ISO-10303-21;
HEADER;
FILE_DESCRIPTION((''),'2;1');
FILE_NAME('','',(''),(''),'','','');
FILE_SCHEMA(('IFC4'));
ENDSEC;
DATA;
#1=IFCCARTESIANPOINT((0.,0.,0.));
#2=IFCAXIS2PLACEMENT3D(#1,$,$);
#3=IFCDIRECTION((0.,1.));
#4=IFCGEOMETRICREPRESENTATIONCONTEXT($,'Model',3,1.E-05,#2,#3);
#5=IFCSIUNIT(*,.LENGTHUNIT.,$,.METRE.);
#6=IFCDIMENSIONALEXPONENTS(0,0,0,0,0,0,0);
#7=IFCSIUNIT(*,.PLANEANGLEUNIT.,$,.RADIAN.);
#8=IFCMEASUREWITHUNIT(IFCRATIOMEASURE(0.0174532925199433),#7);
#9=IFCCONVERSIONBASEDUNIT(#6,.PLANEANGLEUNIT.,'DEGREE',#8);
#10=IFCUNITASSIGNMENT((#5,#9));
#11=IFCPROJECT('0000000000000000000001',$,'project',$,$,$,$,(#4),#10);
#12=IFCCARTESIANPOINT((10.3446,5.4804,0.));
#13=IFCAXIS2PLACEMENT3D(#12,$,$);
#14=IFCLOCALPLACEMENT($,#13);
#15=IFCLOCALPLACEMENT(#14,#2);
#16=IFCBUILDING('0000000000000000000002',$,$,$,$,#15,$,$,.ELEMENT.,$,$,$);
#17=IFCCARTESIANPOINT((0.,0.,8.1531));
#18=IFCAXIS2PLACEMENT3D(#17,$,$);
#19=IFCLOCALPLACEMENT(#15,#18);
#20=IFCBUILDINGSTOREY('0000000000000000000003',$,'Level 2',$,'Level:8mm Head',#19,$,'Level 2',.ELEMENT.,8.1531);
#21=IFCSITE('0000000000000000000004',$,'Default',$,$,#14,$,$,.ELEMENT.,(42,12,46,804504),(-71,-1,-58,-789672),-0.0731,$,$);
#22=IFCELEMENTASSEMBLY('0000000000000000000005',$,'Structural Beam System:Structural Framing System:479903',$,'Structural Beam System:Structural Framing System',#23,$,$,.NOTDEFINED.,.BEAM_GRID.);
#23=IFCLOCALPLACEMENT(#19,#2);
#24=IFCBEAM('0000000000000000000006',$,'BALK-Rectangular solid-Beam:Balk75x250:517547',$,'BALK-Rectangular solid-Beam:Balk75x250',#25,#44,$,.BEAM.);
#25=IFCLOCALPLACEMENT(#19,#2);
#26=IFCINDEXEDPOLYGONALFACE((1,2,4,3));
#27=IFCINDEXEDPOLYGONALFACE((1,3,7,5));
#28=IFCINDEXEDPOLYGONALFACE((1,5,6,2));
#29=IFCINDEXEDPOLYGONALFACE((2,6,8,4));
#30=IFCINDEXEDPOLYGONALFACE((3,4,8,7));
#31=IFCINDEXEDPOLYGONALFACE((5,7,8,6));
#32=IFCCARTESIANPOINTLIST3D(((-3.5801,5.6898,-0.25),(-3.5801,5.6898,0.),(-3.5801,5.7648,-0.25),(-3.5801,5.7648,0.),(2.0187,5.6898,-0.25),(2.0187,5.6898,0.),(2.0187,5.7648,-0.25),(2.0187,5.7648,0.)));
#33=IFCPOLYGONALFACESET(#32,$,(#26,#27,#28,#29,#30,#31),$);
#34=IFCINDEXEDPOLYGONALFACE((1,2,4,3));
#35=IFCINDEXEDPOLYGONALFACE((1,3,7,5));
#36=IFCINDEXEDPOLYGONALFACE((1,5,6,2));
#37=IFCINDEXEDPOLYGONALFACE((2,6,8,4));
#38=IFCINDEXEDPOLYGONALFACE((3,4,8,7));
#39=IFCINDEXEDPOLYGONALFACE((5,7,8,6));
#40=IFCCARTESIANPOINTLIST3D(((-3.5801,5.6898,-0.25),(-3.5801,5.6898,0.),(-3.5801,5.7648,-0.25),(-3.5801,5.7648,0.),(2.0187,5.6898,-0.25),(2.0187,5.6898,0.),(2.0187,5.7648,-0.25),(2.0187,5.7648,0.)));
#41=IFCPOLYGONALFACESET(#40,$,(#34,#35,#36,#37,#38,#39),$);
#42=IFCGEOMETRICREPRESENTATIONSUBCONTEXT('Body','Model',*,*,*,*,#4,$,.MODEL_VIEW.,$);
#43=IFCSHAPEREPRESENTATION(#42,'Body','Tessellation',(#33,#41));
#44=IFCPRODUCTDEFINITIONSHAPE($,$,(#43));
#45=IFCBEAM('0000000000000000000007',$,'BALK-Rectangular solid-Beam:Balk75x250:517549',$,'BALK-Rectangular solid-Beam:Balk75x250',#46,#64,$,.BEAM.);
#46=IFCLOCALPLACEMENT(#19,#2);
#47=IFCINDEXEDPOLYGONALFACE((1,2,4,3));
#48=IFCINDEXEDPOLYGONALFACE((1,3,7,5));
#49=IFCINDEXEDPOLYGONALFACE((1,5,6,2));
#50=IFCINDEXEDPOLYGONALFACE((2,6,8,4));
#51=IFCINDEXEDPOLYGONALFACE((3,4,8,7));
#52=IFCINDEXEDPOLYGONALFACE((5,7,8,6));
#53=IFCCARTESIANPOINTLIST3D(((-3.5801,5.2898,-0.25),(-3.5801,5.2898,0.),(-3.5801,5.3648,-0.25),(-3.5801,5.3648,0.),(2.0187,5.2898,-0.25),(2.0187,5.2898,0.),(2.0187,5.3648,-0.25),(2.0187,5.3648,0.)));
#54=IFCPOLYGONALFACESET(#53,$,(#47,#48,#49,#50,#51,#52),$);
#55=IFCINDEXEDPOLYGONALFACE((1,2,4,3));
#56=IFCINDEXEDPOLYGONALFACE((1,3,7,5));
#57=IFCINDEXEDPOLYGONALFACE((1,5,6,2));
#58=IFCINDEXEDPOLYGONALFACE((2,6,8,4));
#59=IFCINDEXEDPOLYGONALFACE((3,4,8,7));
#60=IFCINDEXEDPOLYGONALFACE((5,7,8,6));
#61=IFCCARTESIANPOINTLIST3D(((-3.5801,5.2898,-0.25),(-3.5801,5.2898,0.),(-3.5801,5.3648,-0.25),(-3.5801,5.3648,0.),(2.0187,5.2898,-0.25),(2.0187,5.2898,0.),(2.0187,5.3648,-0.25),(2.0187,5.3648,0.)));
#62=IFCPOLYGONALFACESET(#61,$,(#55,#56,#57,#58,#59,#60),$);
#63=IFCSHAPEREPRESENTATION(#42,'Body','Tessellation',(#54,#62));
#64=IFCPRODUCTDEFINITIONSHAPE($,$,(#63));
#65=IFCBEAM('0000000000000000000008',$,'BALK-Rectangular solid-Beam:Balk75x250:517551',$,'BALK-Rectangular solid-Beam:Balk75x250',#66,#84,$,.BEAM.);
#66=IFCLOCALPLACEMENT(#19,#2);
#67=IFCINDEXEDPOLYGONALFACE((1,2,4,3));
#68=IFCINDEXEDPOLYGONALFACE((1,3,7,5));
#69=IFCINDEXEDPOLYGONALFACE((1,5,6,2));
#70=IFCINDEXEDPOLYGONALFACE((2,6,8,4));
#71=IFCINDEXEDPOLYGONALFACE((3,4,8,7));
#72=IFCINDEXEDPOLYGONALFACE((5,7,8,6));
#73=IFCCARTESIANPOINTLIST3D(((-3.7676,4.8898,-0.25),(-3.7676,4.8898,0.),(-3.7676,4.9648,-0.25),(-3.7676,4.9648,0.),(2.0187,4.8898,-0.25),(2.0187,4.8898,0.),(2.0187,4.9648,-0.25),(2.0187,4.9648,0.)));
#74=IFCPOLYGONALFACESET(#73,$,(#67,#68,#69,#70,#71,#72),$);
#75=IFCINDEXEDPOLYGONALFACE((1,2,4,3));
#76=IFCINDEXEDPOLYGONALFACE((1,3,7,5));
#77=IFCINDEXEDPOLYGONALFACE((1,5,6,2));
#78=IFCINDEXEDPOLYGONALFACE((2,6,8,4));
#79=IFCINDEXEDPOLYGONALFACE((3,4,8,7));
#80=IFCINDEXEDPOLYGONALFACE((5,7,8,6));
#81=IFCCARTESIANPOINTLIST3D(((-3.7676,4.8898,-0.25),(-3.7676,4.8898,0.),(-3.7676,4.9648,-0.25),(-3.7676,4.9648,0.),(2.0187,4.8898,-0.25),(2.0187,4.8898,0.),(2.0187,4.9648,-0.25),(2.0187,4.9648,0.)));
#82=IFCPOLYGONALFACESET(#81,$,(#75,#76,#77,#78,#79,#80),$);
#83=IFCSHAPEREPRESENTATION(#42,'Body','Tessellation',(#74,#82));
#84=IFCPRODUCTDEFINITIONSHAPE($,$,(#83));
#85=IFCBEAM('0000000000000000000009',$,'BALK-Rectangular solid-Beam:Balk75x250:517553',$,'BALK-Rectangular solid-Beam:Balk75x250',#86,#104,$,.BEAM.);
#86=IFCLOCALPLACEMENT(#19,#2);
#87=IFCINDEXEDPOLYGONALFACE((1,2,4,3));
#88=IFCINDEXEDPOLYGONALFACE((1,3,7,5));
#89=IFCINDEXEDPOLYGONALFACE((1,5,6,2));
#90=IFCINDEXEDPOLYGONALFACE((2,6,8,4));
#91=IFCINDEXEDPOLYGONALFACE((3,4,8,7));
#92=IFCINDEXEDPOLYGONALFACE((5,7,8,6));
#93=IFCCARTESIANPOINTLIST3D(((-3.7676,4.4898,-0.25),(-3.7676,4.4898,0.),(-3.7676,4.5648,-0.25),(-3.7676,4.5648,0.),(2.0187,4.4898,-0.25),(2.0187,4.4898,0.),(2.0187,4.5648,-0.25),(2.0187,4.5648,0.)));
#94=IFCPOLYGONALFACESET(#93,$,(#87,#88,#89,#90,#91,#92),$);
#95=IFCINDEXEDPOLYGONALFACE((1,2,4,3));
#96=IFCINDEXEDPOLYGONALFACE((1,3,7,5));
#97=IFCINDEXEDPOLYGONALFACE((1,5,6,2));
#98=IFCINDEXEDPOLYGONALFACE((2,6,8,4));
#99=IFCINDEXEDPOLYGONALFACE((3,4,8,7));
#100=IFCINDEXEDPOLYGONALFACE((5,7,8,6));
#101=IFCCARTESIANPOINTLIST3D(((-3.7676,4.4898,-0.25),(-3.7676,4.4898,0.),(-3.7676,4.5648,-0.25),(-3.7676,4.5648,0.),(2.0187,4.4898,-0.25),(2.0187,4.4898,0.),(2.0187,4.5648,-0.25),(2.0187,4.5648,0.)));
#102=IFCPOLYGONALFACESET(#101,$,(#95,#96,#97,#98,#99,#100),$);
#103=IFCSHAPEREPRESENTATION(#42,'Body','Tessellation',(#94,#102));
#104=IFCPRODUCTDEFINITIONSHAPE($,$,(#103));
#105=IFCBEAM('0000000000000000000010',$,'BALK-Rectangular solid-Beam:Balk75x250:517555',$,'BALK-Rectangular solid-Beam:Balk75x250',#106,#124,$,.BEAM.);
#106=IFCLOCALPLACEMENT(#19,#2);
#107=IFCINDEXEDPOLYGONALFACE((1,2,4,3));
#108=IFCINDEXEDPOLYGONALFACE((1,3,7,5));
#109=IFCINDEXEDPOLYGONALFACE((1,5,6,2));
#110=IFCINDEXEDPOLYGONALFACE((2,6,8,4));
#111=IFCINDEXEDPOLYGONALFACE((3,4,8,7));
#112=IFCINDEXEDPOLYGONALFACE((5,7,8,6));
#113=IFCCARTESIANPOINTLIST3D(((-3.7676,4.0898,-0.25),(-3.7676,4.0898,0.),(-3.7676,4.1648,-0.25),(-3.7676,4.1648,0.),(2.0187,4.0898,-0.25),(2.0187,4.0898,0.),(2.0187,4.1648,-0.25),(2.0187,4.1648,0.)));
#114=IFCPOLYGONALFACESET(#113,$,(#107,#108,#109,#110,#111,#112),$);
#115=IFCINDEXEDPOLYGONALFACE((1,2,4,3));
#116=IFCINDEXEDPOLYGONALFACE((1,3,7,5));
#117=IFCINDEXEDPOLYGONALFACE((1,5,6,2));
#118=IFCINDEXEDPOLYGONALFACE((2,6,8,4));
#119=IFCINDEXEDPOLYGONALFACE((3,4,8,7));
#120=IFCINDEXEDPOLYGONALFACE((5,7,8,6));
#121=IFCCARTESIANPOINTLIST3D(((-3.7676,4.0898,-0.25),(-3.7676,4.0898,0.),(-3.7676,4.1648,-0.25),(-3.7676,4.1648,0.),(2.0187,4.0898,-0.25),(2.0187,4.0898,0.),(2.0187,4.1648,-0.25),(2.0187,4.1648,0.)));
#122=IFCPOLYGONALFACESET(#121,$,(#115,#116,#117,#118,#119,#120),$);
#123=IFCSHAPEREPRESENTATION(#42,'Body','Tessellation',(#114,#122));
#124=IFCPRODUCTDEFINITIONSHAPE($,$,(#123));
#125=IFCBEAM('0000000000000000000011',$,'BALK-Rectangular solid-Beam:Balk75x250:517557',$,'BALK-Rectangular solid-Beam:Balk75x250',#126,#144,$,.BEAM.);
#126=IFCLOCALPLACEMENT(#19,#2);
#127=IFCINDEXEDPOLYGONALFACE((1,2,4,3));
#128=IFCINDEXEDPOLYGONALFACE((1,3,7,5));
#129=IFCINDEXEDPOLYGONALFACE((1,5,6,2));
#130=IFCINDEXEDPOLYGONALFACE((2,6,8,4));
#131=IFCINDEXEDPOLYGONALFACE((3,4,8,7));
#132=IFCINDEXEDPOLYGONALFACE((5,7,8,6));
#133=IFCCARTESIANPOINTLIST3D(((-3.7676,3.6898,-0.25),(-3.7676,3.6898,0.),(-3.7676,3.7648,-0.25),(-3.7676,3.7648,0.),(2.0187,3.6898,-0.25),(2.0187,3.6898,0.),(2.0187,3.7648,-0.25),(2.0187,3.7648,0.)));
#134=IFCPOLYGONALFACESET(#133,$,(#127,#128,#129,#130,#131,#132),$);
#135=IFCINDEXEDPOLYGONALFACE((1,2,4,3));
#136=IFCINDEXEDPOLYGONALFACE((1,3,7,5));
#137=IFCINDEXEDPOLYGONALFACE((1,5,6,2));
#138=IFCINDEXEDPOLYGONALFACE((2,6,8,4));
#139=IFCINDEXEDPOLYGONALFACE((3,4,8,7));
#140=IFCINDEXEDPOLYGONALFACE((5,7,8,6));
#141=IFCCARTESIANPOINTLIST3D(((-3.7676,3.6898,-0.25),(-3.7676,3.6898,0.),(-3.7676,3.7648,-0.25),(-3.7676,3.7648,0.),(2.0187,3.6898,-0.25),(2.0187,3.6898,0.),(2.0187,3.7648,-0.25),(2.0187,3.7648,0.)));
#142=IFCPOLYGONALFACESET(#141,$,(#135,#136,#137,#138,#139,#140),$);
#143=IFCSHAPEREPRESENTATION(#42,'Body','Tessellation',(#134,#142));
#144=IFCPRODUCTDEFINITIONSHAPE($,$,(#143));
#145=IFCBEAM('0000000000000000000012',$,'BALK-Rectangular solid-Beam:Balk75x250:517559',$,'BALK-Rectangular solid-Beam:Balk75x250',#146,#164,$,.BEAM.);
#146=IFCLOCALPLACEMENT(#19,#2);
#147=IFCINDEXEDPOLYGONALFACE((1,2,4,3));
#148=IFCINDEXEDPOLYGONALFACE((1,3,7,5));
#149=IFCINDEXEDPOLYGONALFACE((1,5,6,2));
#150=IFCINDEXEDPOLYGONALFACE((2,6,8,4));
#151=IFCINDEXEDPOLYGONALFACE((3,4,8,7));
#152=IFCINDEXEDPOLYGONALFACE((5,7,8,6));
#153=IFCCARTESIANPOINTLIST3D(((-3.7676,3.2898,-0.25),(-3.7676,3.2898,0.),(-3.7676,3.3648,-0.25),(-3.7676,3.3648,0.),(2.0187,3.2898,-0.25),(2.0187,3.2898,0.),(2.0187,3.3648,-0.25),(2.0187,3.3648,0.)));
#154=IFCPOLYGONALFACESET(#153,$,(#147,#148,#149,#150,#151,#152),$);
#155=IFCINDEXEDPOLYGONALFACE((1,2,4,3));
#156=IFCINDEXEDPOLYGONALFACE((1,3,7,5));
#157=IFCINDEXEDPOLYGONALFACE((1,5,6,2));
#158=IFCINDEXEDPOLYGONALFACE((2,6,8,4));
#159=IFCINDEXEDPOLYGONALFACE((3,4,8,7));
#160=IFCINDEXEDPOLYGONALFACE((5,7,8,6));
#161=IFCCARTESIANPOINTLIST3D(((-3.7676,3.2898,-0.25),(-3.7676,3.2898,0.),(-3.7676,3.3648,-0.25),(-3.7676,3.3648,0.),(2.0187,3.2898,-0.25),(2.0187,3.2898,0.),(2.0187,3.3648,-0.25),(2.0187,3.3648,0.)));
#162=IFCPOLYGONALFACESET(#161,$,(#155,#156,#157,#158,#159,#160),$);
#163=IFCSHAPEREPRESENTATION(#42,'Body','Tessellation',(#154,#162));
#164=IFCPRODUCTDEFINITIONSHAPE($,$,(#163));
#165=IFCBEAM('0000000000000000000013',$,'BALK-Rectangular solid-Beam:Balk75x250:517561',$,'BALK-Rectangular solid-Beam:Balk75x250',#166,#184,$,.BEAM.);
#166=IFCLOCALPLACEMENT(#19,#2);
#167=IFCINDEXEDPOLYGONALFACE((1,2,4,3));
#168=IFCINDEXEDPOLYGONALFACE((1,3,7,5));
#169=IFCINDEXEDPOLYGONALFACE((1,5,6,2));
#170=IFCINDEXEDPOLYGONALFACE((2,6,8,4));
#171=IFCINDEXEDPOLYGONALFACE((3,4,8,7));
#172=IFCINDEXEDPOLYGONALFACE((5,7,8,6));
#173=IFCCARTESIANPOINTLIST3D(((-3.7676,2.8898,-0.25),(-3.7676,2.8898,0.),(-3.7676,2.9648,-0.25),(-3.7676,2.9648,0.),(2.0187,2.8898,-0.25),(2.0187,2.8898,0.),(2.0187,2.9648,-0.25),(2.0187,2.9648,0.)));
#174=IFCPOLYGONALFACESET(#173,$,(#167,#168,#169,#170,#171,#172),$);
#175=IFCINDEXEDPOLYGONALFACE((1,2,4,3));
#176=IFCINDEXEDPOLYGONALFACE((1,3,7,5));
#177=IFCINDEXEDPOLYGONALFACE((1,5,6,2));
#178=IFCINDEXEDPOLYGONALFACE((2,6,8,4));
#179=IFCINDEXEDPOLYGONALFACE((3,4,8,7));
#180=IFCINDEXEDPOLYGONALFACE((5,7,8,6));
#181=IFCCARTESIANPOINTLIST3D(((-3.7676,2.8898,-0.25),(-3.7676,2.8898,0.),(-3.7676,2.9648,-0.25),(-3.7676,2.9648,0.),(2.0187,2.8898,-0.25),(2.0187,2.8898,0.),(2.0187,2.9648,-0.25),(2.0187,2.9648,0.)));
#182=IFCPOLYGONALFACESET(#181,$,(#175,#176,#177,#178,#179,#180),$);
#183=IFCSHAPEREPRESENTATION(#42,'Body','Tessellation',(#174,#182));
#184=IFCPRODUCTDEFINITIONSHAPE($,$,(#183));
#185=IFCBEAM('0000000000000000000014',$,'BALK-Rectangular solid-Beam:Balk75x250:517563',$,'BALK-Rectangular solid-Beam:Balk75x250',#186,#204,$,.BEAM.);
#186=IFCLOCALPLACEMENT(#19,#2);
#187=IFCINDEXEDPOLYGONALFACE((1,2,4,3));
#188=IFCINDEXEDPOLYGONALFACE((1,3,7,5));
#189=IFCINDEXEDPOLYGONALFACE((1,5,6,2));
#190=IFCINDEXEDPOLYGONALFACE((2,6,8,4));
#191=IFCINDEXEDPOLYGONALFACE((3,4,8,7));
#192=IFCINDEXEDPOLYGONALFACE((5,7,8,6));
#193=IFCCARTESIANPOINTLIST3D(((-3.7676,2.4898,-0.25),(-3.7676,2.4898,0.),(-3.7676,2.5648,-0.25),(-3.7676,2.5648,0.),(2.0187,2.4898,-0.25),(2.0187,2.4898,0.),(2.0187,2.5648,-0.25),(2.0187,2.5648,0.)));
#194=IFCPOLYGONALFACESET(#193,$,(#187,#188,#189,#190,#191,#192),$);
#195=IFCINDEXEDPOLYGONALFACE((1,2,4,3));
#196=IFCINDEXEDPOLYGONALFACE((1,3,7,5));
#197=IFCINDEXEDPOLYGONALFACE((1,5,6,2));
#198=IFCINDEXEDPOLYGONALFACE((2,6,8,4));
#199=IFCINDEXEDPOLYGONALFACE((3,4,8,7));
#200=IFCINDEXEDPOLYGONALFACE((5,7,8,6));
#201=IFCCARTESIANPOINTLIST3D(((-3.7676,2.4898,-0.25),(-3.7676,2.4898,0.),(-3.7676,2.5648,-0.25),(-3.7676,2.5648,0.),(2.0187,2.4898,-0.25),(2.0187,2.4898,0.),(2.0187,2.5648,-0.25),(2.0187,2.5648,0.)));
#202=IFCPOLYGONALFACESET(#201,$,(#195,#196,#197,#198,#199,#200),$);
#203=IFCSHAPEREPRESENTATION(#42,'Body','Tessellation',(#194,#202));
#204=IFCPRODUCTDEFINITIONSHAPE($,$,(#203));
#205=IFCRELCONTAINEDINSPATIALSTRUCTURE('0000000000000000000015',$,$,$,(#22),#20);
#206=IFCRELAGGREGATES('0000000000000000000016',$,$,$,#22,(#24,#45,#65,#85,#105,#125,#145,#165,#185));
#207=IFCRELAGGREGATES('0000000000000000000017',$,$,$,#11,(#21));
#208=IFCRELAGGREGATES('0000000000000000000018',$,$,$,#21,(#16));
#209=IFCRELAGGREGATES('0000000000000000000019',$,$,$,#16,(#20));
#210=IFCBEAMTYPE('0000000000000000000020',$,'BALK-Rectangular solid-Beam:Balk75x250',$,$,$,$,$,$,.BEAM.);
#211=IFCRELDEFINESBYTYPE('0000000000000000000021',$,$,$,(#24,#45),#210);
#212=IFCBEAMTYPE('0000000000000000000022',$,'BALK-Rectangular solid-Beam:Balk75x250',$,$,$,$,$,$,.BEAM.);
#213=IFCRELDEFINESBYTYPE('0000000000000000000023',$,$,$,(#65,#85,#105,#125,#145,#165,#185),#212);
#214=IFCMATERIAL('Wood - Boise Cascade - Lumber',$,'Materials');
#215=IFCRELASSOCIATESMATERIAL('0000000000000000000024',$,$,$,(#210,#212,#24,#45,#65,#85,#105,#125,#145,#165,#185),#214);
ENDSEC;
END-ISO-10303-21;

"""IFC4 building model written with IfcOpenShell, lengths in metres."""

from ifc_helpers import new_model, entity, si_unit, converted_unit, direction, frame, frame_2d, origin, origin_2d_with_axis, place, context, subcontext, project, spatial, rectangle, extrude, source, transform, mapped, material, material_profile, profile_set, profile_usage, type_object, type_shapes, element, aggregate, save


model = new_model("IFC4")

# Units and contexts
model_context = context("Model", 3, precision=1e-05, world=origin(), true_north=direction((0.0, 1.0)))
body_context = subcontext(model_context, "Body", "Model", "MODEL_VIEW")
ifc_project = project(units=[si_unit("LENGTHUNIT", "METRE"), converted_unit("PLANEANGLEUNIT", "DEGREE", entity("IfcRatioMeasure", 0.0174532925199433), si_unit("PLANEANGLEUNIT", "RADIAN"), dimensions=[0, 0, 0, 0, 0, 0, 0])], contexts=[model_context])

# Site, building, storey
site_placement = place(None, frame((10.3446, 5.4804, 0.0)))
site = spatial("IfcSite", under=ifc_project, at=site_placement, Name="Default", CompositionType="ELEMENT", RefLatitude=(42, 12, 46, 804504), RefLongitude=(-71, -1, -58, -789672), RefElevation=-0.0731)
building_placement = place(site_placement, origin())
building = spatial("IfcBuilding", under=site, at=building_placement, CompositionType="ELEMENT")
storey_placement = place(building_placement, frame((0.0, 0.0, 8.1531)))
storey = spatial("IfcBuildingStorey", under=building, at=storey_placement, Name="Level 2", ObjectType="Level:8mm Head", LongName="Level 2", CompositionType="ELEMENT", Elevation=8.1531)

# Element assembly, beams
ifc_material_1 = material(Name="Wood - Boise Cascade - Lumber", Category="Materials")
ifc_material_profile = material_profile(ifc_material_1, rectangle(XDim=0.25, YDim=0.075, at=frame_2d((0.0, 0.0), x_axis=(1.0, 0.0))), Name="Balk75x250")
ifc_profile_set = profile_set([ifc_material_profile], Name="Balk75x250")
assembly_1_placement = place(storey_placement, origin())
assembly_1 = element("IfcElementAssembly", 1, at=assembly_1_placement, inside=storey, Name="Structural Beam System:Structural Framing System:479903", ObjectType="Structural Beam System:Structural Framing System", AssemblyPlace="NOTDEFINED", PredefinedType="BEAM_GRID")
ifc_profile_usage_1 = profile_usage(ifc_profile_set, cardinal=8)
beam_type_1 = type_object("IfcBeamType", Name="BALK-Rectangular solid-Beam:Balk75x250", PredefinedType="BEAM", material=ifc_profile_set)
shared_shape_1 = source(origin(), body_context, "Body", "SweptSolid", [
    extrude(rectangle(XDim=0.25, YDim=0.075, at=origin_2d_with_axis()), frame((-2.7994, 0.0, 0.0), z_axis=(1.0, 0.0, 0.0), x_axis=(0.0, 0.0, -1.0)), (0.0, 0.0, 1.0), 5.5988),
    extrude(rectangle(XDim=0.25, YDim=0.075, at=origin_2d_with_axis()), frame((-2.7994, 0.0, 0.0), z_axis=(1.0, 0.0, 0.0), x_axis=(0.0, 0.0, -1.0)), (0.0, 0.0, 1.0), 5.5988),
])
type_shapes(beam_type_1, [shared_shape_1])
beam_1_placement = place(assembly_1_placement, frame((-0.7807, 5.7273, -0.125)))
beam_1 = element("IfcBeam", 2, at=beam_1_placement, type_object=beam_type_1, material=ifc_profile_usage_1, Name="BALK-Rectangular solid-Beam:Balk75x250:517547", ObjectType="BALK-Rectangular solid-Beam:Balk75x250", PredefinedType="BEAM", context=body_context, shape_type="MappedRepresentation", body=[
    mapped(shared_shape_1, transform((0.0, 0.0, 0.0), scale=1.0)),
])
ifc_profile_usage_2 = profile_usage(ifc_profile_set, cardinal=8)
beam_2_placement = place(assembly_1_placement, frame((-0.7807, 5.3273, -0.125)))
beam_2 = element("IfcBeam", 3, at=beam_2_placement, type_object=beam_type_1, material=ifc_profile_usage_2, Name="BALK-Rectangular solid-Beam:Balk75x250:517549", ObjectType="BALK-Rectangular solid-Beam:Balk75x250", PredefinedType="BEAM", context=body_context, shape_type="MappedRepresentation", body=[
    mapped(shared_shape_1, transform((0.0, 0.0, 0.0), scale=1.0)),
])
ifc_profile_usage_3 = profile_usage(ifc_profile_set, cardinal=8)
beam_type_2 = type_object("IfcBeamType", Name="BALK-Rectangular solid-Beam:Balk75x250", PredefinedType="BEAM", material=ifc_profile_set)
shared_shape_2 = source(origin(), body_context, "Body", "SweptSolid", [
    extrude(rectangle(XDim=0.25, YDim=0.075, at=origin_2d_with_axis()), frame((-2.9869, 0.0, 0.0), z_axis=(1.0, 0.0, 0.0), x_axis=(0.0, 0.0, -1.0)), (0.0, 0.0, 1.0), 5.7863),
    extrude(rectangle(XDim=0.25, YDim=0.075, at=origin_2d_with_axis()), frame((-2.9869, 0.0, 0.0), z_axis=(1.0, 0.0, 0.0), x_axis=(0.0, 0.0, -1.0)), (0.0, 0.0, 1.0), 5.7863),
])
type_shapes(beam_type_2, [shared_shape_2])
beam_3_placement = place(assembly_1_placement, frame((-0.7807, 4.9273, -0.125)))
beam_3 = element("IfcBeam", 4, at=beam_3_placement, type_object=beam_type_2, material=ifc_profile_usage_3, Name="BALK-Rectangular solid-Beam:Balk75x250:517551", ObjectType="BALK-Rectangular solid-Beam:Balk75x250", PredefinedType="BEAM", context=body_context, shape_type="MappedRepresentation", body=[
    mapped(shared_shape_2, transform((0.0, 0.0, 0.0), scale=1.0)),
])
ifc_profile_usage_4 = profile_usage(ifc_profile_set, cardinal=8)
beam_4_placement = place(assembly_1_placement, frame((-0.7807, 4.5273, -0.125)))
beam_4 = element("IfcBeam", 5, at=beam_4_placement, type_object=beam_type_2, material=ifc_profile_usage_4, Name="BALK-Rectangular solid-Beam:Balk75x250:517553", ObjectType="BALK-Rectangular solid-Beam:Balk75x250", PredefinedType="BEAM", context=body_context, shape_type="MappedRepresentation", body=[
    mapped(shared_shape_2, transform((0.0, 0.0, 0.0), scale=1.0)),
])
ifc_profile_usage_5 = profile_usage(ifc_profile_set, cardinal=8)
beam_5_placement = place(assembly_1_placement, frame((-0.7807, 4.1273, -0.125)))
beam_5 = element("IfcBeam", 6, at=beam_5_placement, type_object=beam_type_2, material=ifc_profile_usage_5, Name="BALK-Rectangular solid-Beam:Balk75x250:517555", ObjectType="BALK-Rectangular solid-Beam:Balk75x250", PredefinedType="BEAM", context=body_context, shape_type="MappedRepresentation", body=[
    mapped(shared_shape_2, transform((0.0, 0.0, 0.0), scale=1.0)),
])
ifc_profile_usage_6 = profile_usage(ifc_profile_set, cardinal=8)
beam_6_placement = place(assembly_1_placement, frame((-0.7807, 3.7273, -0.125)))
beam_6 = element("IfcBeam", 7, at=beam_6_placement, type_object=beam_type_2, material=ifc_profile_usage_6, Name="BALK-Rectangular solid-Beam:Balk75x250:517557", ObjectType="BALK-Rectangular solid-Beam:Balk75x250", PredefinedType="BEAM", context=body_context, shape_type="MappedRepresentation", body=[
    mapped(shared_shape_2, transform((0.0, 0.0, 0.0), scale=1.0)),
])
ifc_profile_usage_7 = profile_usage(ifc_profile_set, cardinal=8)
beam_7_placement = place(assembly_1_placement, frame((-0.7807, 3.3273, -0.125)))
beam_7 = element("IfcBeam", 8, at=beam_7_placement, type_object=beam_type_2, material=ifc_profile_usage_7, Name="BALK-Rectangular solid-Beam:Balk75x250:517559", ObjectType="BALK-Rectangular solid-Beam:Balk75x250", PredefinedType="BEAM", context=body_context, shape_type="MappedRepresentation", body=[
    mapped(shared_shape_2, transform((0.0, 0.0, 0.0), scale=1.0)),
])
ifc_profile_usage_8 = profile_usage(ifc_profile_set, cardinal=8)
beam_8_placement = place(assembly_1_placement, frame((-0.7807, 2.9273, -0.125)))
beam_8 = element("IfcBeam", 9, at=beam_8_placement, type_object=beam_type_2, material=ifc_profile_usage_8, Name="BALK-Rectangular solid-Beam:Balk75x250:517561", ObjectType="BALK-Rectangular solid-Beam:Balk75x250", PredefinedType="BEAM", context=body_context, shape_type="MappedRepresentation", body=[
    mapped(shared_shape_2, transform((0.0, 0.0, 0.0), scale=1.0)),
])
ifc_profile_usage_9 = profile_usage(ifc_profile_set, cardinal=8)
beam_9_placement = place(assembly_1_placement, frame((-0.7807, 2.5273, -0.125)))
beam_9 = element("IfcBeam", 10, at=beam_9_placement, type_object=beam_type_2, material=ifc_profile_usage_9, Name="BALK-Rectangular solid-Beam:Balk75x250:517563", ObjectType="BALK-Rectangular solid-Beam:Balk75x250", PredefinedType="BEAM", context=body_context, shape_type="MappedRepresentation", body=[
    mapped(shared_shape_2, transform((0.0, 0.0, 0.0), scale=1.0)),
])
aggregate(assembly_1, [beam_1, beam_2, beam_3, beam_4, beam_5, beam_6, beam_7, beam_8, beam_9])

save(model, "model.ifc")
